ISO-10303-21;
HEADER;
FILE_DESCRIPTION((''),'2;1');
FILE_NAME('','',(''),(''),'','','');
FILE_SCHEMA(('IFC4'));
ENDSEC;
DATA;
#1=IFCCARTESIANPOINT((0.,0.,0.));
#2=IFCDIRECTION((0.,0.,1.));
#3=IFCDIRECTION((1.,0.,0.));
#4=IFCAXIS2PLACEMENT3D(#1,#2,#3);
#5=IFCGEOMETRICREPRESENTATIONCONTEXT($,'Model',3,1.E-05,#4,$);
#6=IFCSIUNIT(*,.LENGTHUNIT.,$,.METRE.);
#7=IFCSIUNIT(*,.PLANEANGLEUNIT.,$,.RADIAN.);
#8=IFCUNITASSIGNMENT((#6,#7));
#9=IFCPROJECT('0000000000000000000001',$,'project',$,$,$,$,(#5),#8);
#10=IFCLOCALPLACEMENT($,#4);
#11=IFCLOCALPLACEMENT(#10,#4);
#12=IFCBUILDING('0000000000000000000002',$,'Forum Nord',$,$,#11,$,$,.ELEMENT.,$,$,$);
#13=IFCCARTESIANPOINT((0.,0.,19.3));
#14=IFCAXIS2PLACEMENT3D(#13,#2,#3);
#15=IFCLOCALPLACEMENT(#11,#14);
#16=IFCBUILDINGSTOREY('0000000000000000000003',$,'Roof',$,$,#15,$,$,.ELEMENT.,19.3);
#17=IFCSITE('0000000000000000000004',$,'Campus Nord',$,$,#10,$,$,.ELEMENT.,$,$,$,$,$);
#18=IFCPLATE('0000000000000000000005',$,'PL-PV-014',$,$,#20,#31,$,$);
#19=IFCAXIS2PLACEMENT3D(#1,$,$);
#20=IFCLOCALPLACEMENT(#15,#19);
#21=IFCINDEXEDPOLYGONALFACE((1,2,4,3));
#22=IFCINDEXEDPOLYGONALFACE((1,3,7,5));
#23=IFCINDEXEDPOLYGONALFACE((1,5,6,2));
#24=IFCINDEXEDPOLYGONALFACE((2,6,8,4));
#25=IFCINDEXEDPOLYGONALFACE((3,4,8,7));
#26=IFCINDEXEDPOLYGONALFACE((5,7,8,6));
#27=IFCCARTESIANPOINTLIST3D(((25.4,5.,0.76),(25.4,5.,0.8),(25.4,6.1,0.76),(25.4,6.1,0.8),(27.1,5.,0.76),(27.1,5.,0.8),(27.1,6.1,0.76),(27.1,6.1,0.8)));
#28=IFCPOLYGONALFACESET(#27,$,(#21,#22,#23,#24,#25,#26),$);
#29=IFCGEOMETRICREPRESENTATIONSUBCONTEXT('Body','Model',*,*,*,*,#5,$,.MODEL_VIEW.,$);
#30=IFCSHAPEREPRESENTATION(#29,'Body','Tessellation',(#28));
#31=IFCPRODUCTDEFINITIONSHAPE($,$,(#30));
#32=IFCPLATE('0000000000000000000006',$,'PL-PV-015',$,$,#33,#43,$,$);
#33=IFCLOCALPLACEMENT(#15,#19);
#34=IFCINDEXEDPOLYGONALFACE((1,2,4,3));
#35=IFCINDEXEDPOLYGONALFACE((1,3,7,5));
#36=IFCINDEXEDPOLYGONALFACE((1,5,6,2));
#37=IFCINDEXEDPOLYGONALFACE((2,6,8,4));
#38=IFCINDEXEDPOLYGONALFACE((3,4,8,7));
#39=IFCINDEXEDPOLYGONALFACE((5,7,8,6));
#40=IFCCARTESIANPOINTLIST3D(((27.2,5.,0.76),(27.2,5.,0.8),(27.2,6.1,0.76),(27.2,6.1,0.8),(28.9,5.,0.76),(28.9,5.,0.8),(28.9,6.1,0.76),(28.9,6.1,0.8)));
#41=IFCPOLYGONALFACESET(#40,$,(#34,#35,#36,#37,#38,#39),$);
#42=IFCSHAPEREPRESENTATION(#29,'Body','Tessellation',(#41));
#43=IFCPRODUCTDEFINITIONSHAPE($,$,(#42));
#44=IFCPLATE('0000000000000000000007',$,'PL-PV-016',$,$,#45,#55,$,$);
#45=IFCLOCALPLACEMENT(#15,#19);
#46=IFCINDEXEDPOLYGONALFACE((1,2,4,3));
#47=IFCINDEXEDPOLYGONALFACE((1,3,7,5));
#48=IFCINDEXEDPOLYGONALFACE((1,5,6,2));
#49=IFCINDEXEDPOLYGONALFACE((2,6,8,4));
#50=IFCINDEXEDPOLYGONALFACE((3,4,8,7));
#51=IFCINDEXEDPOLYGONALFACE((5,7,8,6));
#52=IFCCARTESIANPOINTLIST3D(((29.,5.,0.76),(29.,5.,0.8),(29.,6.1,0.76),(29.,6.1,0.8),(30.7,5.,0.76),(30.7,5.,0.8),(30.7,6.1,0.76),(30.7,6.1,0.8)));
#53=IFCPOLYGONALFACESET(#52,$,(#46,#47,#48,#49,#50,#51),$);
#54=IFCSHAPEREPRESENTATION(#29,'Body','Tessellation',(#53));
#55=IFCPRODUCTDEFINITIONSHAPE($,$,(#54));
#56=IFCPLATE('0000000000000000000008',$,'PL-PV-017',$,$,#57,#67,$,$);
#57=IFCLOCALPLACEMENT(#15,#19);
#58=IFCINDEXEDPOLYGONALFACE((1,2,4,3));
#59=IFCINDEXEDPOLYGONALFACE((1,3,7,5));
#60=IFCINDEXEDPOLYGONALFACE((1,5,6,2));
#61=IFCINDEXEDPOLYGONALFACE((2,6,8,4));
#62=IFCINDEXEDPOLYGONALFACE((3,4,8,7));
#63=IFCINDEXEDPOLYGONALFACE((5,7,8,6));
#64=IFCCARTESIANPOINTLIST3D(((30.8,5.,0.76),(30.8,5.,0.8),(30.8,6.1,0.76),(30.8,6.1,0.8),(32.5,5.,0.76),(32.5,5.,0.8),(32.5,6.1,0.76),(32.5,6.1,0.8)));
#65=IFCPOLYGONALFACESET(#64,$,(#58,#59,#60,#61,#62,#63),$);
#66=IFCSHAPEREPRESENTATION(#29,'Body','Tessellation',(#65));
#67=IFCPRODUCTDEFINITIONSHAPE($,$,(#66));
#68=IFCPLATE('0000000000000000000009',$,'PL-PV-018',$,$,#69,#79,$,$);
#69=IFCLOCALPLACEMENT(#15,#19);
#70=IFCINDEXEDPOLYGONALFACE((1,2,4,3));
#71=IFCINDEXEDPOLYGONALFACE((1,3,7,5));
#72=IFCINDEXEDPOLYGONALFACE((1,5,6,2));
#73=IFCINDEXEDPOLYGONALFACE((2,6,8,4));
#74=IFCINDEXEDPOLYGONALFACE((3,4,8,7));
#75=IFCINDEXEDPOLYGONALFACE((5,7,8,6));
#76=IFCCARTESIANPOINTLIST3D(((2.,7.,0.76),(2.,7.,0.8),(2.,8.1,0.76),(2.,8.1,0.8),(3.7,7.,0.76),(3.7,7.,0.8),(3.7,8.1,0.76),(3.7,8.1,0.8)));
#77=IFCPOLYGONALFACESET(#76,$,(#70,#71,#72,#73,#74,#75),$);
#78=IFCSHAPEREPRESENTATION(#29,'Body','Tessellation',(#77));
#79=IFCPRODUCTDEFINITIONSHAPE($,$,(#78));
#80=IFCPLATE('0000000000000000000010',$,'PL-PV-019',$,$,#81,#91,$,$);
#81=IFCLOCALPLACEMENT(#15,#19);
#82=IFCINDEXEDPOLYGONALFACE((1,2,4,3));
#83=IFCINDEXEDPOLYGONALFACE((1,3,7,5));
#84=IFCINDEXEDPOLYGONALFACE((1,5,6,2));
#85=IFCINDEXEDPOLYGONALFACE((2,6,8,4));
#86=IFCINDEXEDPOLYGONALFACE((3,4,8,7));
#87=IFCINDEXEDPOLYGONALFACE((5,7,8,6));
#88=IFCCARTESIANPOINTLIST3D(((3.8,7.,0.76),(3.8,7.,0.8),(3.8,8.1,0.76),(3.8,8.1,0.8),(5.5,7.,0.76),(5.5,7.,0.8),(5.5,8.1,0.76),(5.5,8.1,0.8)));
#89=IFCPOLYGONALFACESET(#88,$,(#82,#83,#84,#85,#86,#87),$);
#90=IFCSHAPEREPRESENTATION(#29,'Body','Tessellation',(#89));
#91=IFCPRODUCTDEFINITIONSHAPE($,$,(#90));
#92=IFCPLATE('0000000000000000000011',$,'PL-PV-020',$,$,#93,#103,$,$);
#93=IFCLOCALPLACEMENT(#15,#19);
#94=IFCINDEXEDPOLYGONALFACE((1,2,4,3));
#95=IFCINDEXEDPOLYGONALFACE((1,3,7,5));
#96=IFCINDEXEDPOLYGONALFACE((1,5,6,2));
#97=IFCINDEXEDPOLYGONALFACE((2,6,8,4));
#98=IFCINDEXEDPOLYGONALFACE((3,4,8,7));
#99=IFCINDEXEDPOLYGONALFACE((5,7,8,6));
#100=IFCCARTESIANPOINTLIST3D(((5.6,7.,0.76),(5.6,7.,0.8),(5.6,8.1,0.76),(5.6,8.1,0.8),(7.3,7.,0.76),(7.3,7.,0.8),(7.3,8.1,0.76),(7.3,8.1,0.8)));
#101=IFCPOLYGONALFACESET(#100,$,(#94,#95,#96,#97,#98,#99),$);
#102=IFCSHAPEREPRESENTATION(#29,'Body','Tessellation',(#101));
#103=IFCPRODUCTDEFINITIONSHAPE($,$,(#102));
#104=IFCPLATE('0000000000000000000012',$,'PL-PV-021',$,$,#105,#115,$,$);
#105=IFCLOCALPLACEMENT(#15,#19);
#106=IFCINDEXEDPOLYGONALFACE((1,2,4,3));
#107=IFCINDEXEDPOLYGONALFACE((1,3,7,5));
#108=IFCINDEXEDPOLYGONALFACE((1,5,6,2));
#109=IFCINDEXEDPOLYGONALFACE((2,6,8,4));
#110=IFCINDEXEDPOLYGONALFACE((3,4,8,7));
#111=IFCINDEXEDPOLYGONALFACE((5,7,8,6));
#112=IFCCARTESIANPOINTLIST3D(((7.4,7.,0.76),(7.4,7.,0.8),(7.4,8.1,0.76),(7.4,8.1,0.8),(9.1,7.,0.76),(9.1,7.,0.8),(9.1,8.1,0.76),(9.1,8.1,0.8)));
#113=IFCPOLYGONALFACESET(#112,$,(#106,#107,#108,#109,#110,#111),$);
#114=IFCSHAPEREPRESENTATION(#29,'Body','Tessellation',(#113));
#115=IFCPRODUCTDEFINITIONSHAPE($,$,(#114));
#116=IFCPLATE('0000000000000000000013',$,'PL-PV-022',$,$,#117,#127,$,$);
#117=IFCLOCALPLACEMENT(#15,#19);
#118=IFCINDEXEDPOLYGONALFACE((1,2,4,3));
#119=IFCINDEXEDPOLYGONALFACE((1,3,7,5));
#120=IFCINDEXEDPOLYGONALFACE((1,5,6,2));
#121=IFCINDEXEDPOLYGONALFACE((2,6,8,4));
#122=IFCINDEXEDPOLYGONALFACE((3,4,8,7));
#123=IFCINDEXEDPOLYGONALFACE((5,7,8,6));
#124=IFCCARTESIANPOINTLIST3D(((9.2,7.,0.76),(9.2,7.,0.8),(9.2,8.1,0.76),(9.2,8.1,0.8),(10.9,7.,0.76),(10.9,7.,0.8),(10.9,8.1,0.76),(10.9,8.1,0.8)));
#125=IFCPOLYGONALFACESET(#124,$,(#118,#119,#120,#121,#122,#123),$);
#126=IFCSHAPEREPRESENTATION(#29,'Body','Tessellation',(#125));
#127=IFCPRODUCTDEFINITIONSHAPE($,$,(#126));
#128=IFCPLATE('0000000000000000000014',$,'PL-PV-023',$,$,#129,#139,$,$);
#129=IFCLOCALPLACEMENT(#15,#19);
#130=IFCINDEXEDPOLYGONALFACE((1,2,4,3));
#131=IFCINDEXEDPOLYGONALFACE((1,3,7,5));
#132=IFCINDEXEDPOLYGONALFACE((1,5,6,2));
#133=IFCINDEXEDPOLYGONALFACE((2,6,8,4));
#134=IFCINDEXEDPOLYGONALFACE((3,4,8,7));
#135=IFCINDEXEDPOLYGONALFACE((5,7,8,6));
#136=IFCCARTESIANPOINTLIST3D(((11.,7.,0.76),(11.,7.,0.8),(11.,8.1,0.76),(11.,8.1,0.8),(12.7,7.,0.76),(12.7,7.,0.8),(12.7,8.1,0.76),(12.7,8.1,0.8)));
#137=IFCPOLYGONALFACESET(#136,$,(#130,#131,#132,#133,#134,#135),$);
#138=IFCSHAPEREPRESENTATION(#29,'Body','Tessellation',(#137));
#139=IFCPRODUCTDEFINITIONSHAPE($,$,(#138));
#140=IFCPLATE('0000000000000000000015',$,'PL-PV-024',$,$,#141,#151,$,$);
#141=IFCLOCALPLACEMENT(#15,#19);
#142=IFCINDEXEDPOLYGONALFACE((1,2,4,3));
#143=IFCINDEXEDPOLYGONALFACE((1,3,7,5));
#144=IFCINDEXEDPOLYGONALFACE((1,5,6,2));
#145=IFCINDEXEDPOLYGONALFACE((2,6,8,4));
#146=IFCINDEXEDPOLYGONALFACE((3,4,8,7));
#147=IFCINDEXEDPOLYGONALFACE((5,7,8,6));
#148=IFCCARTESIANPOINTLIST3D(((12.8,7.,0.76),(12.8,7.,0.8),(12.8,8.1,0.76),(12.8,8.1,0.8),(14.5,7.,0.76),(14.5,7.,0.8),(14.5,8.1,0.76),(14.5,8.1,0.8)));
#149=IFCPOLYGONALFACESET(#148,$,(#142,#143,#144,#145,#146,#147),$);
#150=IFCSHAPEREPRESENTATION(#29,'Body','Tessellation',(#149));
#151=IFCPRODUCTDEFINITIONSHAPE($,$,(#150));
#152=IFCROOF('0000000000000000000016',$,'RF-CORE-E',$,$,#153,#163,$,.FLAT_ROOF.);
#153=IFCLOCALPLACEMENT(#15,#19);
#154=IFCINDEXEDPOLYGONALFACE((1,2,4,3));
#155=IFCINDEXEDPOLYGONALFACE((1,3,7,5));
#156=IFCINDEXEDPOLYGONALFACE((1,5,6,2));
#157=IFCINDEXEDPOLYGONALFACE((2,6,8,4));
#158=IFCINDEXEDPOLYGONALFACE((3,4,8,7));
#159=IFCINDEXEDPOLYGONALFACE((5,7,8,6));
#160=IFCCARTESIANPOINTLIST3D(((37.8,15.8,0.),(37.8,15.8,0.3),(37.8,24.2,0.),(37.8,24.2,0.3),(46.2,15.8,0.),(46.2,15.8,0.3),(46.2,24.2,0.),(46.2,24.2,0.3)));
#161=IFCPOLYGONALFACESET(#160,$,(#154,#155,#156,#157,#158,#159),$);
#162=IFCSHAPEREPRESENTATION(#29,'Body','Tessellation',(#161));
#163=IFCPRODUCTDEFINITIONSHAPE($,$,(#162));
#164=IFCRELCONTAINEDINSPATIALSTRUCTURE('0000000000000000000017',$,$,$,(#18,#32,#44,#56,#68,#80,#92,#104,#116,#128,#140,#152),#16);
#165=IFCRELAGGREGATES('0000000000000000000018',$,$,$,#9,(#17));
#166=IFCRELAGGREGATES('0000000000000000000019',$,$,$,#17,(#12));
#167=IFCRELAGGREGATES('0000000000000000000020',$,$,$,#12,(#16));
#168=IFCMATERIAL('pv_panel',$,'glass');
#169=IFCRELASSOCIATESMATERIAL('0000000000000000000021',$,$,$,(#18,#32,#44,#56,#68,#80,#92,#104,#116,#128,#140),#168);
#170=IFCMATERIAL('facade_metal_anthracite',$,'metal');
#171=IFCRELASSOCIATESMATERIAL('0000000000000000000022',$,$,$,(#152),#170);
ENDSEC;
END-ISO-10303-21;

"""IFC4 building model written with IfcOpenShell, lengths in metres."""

from ifc_helpers import new_model, si_unit, frame, origin_with_axes, place, context, subcontext, project, spatial, polyline, outline, extrude, material, element, save


model = new_model("IFC4")

# Units and contexts
model_context = context("Model", 3, precision=1e-05, world=origin_with_axes())
body_context = subcontext(model_context, "Body", "Model", "MODEL_VIEW")
ifc_project = project(units=[si_unit("LENGTHUNIT", "METRE"), si_unit("PLANEANGLEUNIT", "RADIAN")], contexts=[model_context])

# Site, building, storey
site_placement = place(None, origin_with_axes())
site = spatial("IfcSite", under=ifc_project, at=site_placement, Name="Campus Nord", CompositionType="ELEMENT")
building_placement = place(site_placement, origin_with_axes())
building = spatial("IfcBuilding", under=site, at=building_placement, Name="Forum Nord", CompositionType="ELEMENT")
storey_placement = place(building_placement, frame((0.0, 0.0, 19.3), z_axis=(0.0, 0.0, 1.0), x_axis=(1.0, 0.0, 0.0)))
storey = spatial("IfcBuildingStorey", under=building, at=storey_placement, Name="Roof", CompositionType="ELEMENT", Elevation=19.3)

# Shared definitions
ifc_material_1 = material(Name="facade_metal_anthracite", Category="metal")

# Plates
ifc_material_2 = material(Name="pv_panel", Category="glass")
plate_1_placement = place(storey_placement, frame((0.0, 0.0, 0.8), z_axis=(0.0, 0.0, 1.0), x_axis=(1.0, 0.0, 0.0)))
element("IfcPlate", 1, at=plate_1_placement, inside=storey, material=ifc_material_2, Name="PL-PV-014", context=body_context, shape_type="SweptSolid", body=[
    extrude(outline(polyline([(25.4, 5.0), (27.1, 5.0), (27.1, 6.1), (25.4, 6.1), (25.4, 5.0)])), frame((0.0, 0.0, -0.04), z_axis=(0.0, 0.0, 1.0), x_axis=(1.0, 0.0, 0.0)), (0.0, 0.0, 1.0), 0.04),
])
plate_2_placement = place(storey_placement, frame((0.0, 0.0, 0.8), z_axis=(0.0, 0.0, 1.0), x_axis=(1.0, 0.0, 0.0)))
element("IfcPlate", 2, at=plate_2_placement, inside=storey, material=ifc_material_2, Name="PL-PV-015", context=body_context, shape_type="SweptSolid", body=[
    extrude(outline(polyline([(27.2, 5.0), (28.9, 5.0), (28.9, 6.1), (27.2, 6.1), (27.2, 5.0)])), frame((0.0, 0.0, -0.04), z_axis=(0.0, 0.0, 1.0), x_axis=(1.0, 0.0, 0.0)), (0.0, 0.0, 1.0), 0.04),
])
plate_3_placement = place(storey_placement, frame((0.0, 0.0, 0.8), z_axis=(0.0, 0.0, 1.0), x_axis=(1.0, 0.0, 0.0)))
element("IfcPlate", 3, at=plate_3_placement, inside=storey, material=ifc_material_2, Name="PL-PV-016", context=body_context, shape_type="SweptSolid", body=[
    extrude(outline(polyline([(29.0, 5.0), (30.7, 5.0), (30.7, 6.1), (29.0, 6.1), (29.0, 5.0)])), frame((0.0, 0.0, -0.04), z_axis=(0.0, 0.0, 1.0), x_axis=(1.0, 0.0, 0.0)), (0.0, 0.0, 1.0), 0.04),
])
plate_4_placement = place(storey_placement, frame((0.0, 0.0, 0.8), z_axis=(0.0, 0.0, 1.0), x_axis=(1.0, 0.0, 0.0)))
element("IfcPlate", 4, at=plate_4_placement, inside=storey, material=ifc_material_2, Name="PL-PV-017", context=body_context, shape_type="SweptSolid", body=[
    extrude(outline(polyline([(30.8, 5.0), (32.5, 5.0), (32.5, 6.1), (30.8, 6.1), (30.8, 5.0)])), frame((0.0, 0.0, -0.04), z_axis=(0.0, 0.0, 1.0), x_axis=(1.0, 0.0, 0.0)), (0.0, 0.0, 1.0), 0.04),
])
plate_5_placement = place(storey_placement, frame((0.0, 0.0, 0.8), z_axis=(0.0, 0.0, 1.0), x_axis=(1.0, 0.0, 0.0)))
element("IfcPlate", 5, at=plate_5_placement, inside=storey, material=ifc_material_2, Name="PL-PV-018", context=body_context, shape_type="SweptSolid", body=[
    extrude(outline(polyline([(2.0, 7.0), (3.7, 7.0), (3.7, 8.1), (2.0, 8.1), (2.0, 7.0)])), frame((0.0, 0.0, -0.04), z_axis=(0.0, 0.0, 1.0), x_axis=(1.0, 0.0, 0.0)), (0.0, 0.0, 1.0), 0.04),
])
plate_6_placement = place(storey_placement, frame((0.0, 0.0, 0.8), z_axis=(0.0, 0.0, 1.0), x_axis=(1.0, 0.0, 0.0)))
element("IfcPlate", 6, at=plate_6_placement, inside=storey, material=ifc_material_2, Name="PL-PV-019", context=body_context, shape_type="SweptSolid", body=[
    extrude(outline(polyline([(3.8, 7.0), (5.5, 7.0), (5.5, 8.1), (3.8, 8.1), (3.8, 7.0)])), frame((0.0, 0.0, -0.04), z_axis=(0.0, 0.0, 1.0), x_axis=(1.0, 0.0, 0.0)), (0.0, 0.0, 1.0), 0.04),
])
plate_7_placement = place(storey_placement, frame((0.0, 0.0, 0.8), z_axis=(0.0, 0.0, 1.0), x_axis=(1.0, 0.0, 0.0)))
element("IfcPlate", 7, at=plate_7_placement, inside=storey, material=ifc_material_2, Name="PL-PV-020", context=body_context, shape_type="SweptSolid", body=[
    extrude(outline(polyline([(5.6, 7.0), (7.3, 7.0), (7.3, 8.1), (5.6, 8.1), (5.6, 7.0)])), frame((0.0, 0.0, -0.04), z_axis=(0.0, 0.0, 1.0), x_axis=(1.0, 0.0, 0.0)), (0.0, 0.0, 1.0), 0.04),
])
plate_8_placement = place(storey_placement, frame((0.0, 0.0, 0.8), z_axis=(0.0, 0.0, 1.0), x_axis=(1.0, 0.0, 0.0)))
element("IfcPlate", 8, at=plate_8_placement, inside=storey, material=ifc_material_2, Name="PL-PV-021", context=body_context, shape_type="SweptSolid", body=[
    extrude(outline(polyline([(7.4, 7.0), (9.1, 7.0), (9.1, 8.1), (7.4, 8.1), (7.4, 7.0)])), frame((0.0, 0.0, -0.04), z_axis=(0.0, 0.0, 1.0), x_axis=(1.0, 0.0, 0.0)), (0.0, 0.0, 1.0), 0.04),
])
plate_9_placement = place(storey_placement, frame((0.0, 0.0, 0.8), z_axis=(0.0, 0.0, 1.0), x_axis=(1.0, 0.0, 0.0)))
element("IfcPlate", 9, at=plate_9_placement, inside=storey, material=ifc_material_2, Name="PL-PV-022", context=body_context, shape_type="SweptSolid", body=[
    extrude(outline(polyline([(9.2, 7.0), (10.9, 7.0), (10.9, 8.1), (9.2, 8.1), (9.2, 7.0)])), frame((0.0, 0.0, -0.04), z_axis=(0.0, 0.0, 1.0), x_axis=(1.0, 0.0, 0.0)), (0.0, 0.0, 1.0), 0.04),
])
plate_10_placement = place(storey_placement, frame((0.0, 0.0, 0.8), z_axis=(0.0, 0.0, 1.0), x_axis=(1.0, 0.0, 0.0)))
element("IfcPlate", 10, at=plate_10_placement, inside=storey, material=ifc_material_2, Name="PL-PV-023", context=body_context, shape_type="SweptSolid", body=[
    extrude(outline(polyline([(11.0, 7.0), (12.7, 7.0), (12.7, 8.1), (11.0, 8.1), (11.0, 7.0)])), frame((0.0, 0.0, -0.04), z_axis=(0.0, 0.0, 1.0), x_axis=(1.0, 0.0, 0.0)), (0.0, 0.0, 1.0), 0.04),
])
plate_11_placement = place(storey_placement, frame((0.0, 0.0, 0.8), z_axis=(0.0, 0.0, 1.0), x_axis=(1.0, 0.0, 0.0)))
element("IfcPlate", 11, at=plate_11_placement, inside=storey, material=ifc_material_2, Name="PL-PV-024", context=body_context, shape_type="SweptSolid", body=[
    extrude(outline(polyline([(12.8, 7.0), (14.5, 7.0), (14.5, 8.1), (12.8, 8.1), (12.8, 7.0)])), frame((0.0, 0.0, -0.04), z_axis=(0.0, 0.0, 1.0), x_axis=(1.0, 0.0, 0.0)), (0.0, 0.0, 1.0), 0.04),
])

# Roof
roof_placement = place(storey_placement, origin_with_axes())
element("IfcRoof", 12, at=roof_placement, inside=storey, material=ifc_material_1, Name="RF-CORE-E", PredefinedType="FLAT_ROOF", context=body_context, shape_type="SweptSolid", body=[
    extrude(outline(polyline([(37.8, 15.8), (46.2, 15.8), (46.2, 24.2), (37.8, 24.2), (37.8, 15.8)])), origin_with_axes(), (0.0, 0.0, 1.0), 0.3),
])

save(model, "model.ifc")
